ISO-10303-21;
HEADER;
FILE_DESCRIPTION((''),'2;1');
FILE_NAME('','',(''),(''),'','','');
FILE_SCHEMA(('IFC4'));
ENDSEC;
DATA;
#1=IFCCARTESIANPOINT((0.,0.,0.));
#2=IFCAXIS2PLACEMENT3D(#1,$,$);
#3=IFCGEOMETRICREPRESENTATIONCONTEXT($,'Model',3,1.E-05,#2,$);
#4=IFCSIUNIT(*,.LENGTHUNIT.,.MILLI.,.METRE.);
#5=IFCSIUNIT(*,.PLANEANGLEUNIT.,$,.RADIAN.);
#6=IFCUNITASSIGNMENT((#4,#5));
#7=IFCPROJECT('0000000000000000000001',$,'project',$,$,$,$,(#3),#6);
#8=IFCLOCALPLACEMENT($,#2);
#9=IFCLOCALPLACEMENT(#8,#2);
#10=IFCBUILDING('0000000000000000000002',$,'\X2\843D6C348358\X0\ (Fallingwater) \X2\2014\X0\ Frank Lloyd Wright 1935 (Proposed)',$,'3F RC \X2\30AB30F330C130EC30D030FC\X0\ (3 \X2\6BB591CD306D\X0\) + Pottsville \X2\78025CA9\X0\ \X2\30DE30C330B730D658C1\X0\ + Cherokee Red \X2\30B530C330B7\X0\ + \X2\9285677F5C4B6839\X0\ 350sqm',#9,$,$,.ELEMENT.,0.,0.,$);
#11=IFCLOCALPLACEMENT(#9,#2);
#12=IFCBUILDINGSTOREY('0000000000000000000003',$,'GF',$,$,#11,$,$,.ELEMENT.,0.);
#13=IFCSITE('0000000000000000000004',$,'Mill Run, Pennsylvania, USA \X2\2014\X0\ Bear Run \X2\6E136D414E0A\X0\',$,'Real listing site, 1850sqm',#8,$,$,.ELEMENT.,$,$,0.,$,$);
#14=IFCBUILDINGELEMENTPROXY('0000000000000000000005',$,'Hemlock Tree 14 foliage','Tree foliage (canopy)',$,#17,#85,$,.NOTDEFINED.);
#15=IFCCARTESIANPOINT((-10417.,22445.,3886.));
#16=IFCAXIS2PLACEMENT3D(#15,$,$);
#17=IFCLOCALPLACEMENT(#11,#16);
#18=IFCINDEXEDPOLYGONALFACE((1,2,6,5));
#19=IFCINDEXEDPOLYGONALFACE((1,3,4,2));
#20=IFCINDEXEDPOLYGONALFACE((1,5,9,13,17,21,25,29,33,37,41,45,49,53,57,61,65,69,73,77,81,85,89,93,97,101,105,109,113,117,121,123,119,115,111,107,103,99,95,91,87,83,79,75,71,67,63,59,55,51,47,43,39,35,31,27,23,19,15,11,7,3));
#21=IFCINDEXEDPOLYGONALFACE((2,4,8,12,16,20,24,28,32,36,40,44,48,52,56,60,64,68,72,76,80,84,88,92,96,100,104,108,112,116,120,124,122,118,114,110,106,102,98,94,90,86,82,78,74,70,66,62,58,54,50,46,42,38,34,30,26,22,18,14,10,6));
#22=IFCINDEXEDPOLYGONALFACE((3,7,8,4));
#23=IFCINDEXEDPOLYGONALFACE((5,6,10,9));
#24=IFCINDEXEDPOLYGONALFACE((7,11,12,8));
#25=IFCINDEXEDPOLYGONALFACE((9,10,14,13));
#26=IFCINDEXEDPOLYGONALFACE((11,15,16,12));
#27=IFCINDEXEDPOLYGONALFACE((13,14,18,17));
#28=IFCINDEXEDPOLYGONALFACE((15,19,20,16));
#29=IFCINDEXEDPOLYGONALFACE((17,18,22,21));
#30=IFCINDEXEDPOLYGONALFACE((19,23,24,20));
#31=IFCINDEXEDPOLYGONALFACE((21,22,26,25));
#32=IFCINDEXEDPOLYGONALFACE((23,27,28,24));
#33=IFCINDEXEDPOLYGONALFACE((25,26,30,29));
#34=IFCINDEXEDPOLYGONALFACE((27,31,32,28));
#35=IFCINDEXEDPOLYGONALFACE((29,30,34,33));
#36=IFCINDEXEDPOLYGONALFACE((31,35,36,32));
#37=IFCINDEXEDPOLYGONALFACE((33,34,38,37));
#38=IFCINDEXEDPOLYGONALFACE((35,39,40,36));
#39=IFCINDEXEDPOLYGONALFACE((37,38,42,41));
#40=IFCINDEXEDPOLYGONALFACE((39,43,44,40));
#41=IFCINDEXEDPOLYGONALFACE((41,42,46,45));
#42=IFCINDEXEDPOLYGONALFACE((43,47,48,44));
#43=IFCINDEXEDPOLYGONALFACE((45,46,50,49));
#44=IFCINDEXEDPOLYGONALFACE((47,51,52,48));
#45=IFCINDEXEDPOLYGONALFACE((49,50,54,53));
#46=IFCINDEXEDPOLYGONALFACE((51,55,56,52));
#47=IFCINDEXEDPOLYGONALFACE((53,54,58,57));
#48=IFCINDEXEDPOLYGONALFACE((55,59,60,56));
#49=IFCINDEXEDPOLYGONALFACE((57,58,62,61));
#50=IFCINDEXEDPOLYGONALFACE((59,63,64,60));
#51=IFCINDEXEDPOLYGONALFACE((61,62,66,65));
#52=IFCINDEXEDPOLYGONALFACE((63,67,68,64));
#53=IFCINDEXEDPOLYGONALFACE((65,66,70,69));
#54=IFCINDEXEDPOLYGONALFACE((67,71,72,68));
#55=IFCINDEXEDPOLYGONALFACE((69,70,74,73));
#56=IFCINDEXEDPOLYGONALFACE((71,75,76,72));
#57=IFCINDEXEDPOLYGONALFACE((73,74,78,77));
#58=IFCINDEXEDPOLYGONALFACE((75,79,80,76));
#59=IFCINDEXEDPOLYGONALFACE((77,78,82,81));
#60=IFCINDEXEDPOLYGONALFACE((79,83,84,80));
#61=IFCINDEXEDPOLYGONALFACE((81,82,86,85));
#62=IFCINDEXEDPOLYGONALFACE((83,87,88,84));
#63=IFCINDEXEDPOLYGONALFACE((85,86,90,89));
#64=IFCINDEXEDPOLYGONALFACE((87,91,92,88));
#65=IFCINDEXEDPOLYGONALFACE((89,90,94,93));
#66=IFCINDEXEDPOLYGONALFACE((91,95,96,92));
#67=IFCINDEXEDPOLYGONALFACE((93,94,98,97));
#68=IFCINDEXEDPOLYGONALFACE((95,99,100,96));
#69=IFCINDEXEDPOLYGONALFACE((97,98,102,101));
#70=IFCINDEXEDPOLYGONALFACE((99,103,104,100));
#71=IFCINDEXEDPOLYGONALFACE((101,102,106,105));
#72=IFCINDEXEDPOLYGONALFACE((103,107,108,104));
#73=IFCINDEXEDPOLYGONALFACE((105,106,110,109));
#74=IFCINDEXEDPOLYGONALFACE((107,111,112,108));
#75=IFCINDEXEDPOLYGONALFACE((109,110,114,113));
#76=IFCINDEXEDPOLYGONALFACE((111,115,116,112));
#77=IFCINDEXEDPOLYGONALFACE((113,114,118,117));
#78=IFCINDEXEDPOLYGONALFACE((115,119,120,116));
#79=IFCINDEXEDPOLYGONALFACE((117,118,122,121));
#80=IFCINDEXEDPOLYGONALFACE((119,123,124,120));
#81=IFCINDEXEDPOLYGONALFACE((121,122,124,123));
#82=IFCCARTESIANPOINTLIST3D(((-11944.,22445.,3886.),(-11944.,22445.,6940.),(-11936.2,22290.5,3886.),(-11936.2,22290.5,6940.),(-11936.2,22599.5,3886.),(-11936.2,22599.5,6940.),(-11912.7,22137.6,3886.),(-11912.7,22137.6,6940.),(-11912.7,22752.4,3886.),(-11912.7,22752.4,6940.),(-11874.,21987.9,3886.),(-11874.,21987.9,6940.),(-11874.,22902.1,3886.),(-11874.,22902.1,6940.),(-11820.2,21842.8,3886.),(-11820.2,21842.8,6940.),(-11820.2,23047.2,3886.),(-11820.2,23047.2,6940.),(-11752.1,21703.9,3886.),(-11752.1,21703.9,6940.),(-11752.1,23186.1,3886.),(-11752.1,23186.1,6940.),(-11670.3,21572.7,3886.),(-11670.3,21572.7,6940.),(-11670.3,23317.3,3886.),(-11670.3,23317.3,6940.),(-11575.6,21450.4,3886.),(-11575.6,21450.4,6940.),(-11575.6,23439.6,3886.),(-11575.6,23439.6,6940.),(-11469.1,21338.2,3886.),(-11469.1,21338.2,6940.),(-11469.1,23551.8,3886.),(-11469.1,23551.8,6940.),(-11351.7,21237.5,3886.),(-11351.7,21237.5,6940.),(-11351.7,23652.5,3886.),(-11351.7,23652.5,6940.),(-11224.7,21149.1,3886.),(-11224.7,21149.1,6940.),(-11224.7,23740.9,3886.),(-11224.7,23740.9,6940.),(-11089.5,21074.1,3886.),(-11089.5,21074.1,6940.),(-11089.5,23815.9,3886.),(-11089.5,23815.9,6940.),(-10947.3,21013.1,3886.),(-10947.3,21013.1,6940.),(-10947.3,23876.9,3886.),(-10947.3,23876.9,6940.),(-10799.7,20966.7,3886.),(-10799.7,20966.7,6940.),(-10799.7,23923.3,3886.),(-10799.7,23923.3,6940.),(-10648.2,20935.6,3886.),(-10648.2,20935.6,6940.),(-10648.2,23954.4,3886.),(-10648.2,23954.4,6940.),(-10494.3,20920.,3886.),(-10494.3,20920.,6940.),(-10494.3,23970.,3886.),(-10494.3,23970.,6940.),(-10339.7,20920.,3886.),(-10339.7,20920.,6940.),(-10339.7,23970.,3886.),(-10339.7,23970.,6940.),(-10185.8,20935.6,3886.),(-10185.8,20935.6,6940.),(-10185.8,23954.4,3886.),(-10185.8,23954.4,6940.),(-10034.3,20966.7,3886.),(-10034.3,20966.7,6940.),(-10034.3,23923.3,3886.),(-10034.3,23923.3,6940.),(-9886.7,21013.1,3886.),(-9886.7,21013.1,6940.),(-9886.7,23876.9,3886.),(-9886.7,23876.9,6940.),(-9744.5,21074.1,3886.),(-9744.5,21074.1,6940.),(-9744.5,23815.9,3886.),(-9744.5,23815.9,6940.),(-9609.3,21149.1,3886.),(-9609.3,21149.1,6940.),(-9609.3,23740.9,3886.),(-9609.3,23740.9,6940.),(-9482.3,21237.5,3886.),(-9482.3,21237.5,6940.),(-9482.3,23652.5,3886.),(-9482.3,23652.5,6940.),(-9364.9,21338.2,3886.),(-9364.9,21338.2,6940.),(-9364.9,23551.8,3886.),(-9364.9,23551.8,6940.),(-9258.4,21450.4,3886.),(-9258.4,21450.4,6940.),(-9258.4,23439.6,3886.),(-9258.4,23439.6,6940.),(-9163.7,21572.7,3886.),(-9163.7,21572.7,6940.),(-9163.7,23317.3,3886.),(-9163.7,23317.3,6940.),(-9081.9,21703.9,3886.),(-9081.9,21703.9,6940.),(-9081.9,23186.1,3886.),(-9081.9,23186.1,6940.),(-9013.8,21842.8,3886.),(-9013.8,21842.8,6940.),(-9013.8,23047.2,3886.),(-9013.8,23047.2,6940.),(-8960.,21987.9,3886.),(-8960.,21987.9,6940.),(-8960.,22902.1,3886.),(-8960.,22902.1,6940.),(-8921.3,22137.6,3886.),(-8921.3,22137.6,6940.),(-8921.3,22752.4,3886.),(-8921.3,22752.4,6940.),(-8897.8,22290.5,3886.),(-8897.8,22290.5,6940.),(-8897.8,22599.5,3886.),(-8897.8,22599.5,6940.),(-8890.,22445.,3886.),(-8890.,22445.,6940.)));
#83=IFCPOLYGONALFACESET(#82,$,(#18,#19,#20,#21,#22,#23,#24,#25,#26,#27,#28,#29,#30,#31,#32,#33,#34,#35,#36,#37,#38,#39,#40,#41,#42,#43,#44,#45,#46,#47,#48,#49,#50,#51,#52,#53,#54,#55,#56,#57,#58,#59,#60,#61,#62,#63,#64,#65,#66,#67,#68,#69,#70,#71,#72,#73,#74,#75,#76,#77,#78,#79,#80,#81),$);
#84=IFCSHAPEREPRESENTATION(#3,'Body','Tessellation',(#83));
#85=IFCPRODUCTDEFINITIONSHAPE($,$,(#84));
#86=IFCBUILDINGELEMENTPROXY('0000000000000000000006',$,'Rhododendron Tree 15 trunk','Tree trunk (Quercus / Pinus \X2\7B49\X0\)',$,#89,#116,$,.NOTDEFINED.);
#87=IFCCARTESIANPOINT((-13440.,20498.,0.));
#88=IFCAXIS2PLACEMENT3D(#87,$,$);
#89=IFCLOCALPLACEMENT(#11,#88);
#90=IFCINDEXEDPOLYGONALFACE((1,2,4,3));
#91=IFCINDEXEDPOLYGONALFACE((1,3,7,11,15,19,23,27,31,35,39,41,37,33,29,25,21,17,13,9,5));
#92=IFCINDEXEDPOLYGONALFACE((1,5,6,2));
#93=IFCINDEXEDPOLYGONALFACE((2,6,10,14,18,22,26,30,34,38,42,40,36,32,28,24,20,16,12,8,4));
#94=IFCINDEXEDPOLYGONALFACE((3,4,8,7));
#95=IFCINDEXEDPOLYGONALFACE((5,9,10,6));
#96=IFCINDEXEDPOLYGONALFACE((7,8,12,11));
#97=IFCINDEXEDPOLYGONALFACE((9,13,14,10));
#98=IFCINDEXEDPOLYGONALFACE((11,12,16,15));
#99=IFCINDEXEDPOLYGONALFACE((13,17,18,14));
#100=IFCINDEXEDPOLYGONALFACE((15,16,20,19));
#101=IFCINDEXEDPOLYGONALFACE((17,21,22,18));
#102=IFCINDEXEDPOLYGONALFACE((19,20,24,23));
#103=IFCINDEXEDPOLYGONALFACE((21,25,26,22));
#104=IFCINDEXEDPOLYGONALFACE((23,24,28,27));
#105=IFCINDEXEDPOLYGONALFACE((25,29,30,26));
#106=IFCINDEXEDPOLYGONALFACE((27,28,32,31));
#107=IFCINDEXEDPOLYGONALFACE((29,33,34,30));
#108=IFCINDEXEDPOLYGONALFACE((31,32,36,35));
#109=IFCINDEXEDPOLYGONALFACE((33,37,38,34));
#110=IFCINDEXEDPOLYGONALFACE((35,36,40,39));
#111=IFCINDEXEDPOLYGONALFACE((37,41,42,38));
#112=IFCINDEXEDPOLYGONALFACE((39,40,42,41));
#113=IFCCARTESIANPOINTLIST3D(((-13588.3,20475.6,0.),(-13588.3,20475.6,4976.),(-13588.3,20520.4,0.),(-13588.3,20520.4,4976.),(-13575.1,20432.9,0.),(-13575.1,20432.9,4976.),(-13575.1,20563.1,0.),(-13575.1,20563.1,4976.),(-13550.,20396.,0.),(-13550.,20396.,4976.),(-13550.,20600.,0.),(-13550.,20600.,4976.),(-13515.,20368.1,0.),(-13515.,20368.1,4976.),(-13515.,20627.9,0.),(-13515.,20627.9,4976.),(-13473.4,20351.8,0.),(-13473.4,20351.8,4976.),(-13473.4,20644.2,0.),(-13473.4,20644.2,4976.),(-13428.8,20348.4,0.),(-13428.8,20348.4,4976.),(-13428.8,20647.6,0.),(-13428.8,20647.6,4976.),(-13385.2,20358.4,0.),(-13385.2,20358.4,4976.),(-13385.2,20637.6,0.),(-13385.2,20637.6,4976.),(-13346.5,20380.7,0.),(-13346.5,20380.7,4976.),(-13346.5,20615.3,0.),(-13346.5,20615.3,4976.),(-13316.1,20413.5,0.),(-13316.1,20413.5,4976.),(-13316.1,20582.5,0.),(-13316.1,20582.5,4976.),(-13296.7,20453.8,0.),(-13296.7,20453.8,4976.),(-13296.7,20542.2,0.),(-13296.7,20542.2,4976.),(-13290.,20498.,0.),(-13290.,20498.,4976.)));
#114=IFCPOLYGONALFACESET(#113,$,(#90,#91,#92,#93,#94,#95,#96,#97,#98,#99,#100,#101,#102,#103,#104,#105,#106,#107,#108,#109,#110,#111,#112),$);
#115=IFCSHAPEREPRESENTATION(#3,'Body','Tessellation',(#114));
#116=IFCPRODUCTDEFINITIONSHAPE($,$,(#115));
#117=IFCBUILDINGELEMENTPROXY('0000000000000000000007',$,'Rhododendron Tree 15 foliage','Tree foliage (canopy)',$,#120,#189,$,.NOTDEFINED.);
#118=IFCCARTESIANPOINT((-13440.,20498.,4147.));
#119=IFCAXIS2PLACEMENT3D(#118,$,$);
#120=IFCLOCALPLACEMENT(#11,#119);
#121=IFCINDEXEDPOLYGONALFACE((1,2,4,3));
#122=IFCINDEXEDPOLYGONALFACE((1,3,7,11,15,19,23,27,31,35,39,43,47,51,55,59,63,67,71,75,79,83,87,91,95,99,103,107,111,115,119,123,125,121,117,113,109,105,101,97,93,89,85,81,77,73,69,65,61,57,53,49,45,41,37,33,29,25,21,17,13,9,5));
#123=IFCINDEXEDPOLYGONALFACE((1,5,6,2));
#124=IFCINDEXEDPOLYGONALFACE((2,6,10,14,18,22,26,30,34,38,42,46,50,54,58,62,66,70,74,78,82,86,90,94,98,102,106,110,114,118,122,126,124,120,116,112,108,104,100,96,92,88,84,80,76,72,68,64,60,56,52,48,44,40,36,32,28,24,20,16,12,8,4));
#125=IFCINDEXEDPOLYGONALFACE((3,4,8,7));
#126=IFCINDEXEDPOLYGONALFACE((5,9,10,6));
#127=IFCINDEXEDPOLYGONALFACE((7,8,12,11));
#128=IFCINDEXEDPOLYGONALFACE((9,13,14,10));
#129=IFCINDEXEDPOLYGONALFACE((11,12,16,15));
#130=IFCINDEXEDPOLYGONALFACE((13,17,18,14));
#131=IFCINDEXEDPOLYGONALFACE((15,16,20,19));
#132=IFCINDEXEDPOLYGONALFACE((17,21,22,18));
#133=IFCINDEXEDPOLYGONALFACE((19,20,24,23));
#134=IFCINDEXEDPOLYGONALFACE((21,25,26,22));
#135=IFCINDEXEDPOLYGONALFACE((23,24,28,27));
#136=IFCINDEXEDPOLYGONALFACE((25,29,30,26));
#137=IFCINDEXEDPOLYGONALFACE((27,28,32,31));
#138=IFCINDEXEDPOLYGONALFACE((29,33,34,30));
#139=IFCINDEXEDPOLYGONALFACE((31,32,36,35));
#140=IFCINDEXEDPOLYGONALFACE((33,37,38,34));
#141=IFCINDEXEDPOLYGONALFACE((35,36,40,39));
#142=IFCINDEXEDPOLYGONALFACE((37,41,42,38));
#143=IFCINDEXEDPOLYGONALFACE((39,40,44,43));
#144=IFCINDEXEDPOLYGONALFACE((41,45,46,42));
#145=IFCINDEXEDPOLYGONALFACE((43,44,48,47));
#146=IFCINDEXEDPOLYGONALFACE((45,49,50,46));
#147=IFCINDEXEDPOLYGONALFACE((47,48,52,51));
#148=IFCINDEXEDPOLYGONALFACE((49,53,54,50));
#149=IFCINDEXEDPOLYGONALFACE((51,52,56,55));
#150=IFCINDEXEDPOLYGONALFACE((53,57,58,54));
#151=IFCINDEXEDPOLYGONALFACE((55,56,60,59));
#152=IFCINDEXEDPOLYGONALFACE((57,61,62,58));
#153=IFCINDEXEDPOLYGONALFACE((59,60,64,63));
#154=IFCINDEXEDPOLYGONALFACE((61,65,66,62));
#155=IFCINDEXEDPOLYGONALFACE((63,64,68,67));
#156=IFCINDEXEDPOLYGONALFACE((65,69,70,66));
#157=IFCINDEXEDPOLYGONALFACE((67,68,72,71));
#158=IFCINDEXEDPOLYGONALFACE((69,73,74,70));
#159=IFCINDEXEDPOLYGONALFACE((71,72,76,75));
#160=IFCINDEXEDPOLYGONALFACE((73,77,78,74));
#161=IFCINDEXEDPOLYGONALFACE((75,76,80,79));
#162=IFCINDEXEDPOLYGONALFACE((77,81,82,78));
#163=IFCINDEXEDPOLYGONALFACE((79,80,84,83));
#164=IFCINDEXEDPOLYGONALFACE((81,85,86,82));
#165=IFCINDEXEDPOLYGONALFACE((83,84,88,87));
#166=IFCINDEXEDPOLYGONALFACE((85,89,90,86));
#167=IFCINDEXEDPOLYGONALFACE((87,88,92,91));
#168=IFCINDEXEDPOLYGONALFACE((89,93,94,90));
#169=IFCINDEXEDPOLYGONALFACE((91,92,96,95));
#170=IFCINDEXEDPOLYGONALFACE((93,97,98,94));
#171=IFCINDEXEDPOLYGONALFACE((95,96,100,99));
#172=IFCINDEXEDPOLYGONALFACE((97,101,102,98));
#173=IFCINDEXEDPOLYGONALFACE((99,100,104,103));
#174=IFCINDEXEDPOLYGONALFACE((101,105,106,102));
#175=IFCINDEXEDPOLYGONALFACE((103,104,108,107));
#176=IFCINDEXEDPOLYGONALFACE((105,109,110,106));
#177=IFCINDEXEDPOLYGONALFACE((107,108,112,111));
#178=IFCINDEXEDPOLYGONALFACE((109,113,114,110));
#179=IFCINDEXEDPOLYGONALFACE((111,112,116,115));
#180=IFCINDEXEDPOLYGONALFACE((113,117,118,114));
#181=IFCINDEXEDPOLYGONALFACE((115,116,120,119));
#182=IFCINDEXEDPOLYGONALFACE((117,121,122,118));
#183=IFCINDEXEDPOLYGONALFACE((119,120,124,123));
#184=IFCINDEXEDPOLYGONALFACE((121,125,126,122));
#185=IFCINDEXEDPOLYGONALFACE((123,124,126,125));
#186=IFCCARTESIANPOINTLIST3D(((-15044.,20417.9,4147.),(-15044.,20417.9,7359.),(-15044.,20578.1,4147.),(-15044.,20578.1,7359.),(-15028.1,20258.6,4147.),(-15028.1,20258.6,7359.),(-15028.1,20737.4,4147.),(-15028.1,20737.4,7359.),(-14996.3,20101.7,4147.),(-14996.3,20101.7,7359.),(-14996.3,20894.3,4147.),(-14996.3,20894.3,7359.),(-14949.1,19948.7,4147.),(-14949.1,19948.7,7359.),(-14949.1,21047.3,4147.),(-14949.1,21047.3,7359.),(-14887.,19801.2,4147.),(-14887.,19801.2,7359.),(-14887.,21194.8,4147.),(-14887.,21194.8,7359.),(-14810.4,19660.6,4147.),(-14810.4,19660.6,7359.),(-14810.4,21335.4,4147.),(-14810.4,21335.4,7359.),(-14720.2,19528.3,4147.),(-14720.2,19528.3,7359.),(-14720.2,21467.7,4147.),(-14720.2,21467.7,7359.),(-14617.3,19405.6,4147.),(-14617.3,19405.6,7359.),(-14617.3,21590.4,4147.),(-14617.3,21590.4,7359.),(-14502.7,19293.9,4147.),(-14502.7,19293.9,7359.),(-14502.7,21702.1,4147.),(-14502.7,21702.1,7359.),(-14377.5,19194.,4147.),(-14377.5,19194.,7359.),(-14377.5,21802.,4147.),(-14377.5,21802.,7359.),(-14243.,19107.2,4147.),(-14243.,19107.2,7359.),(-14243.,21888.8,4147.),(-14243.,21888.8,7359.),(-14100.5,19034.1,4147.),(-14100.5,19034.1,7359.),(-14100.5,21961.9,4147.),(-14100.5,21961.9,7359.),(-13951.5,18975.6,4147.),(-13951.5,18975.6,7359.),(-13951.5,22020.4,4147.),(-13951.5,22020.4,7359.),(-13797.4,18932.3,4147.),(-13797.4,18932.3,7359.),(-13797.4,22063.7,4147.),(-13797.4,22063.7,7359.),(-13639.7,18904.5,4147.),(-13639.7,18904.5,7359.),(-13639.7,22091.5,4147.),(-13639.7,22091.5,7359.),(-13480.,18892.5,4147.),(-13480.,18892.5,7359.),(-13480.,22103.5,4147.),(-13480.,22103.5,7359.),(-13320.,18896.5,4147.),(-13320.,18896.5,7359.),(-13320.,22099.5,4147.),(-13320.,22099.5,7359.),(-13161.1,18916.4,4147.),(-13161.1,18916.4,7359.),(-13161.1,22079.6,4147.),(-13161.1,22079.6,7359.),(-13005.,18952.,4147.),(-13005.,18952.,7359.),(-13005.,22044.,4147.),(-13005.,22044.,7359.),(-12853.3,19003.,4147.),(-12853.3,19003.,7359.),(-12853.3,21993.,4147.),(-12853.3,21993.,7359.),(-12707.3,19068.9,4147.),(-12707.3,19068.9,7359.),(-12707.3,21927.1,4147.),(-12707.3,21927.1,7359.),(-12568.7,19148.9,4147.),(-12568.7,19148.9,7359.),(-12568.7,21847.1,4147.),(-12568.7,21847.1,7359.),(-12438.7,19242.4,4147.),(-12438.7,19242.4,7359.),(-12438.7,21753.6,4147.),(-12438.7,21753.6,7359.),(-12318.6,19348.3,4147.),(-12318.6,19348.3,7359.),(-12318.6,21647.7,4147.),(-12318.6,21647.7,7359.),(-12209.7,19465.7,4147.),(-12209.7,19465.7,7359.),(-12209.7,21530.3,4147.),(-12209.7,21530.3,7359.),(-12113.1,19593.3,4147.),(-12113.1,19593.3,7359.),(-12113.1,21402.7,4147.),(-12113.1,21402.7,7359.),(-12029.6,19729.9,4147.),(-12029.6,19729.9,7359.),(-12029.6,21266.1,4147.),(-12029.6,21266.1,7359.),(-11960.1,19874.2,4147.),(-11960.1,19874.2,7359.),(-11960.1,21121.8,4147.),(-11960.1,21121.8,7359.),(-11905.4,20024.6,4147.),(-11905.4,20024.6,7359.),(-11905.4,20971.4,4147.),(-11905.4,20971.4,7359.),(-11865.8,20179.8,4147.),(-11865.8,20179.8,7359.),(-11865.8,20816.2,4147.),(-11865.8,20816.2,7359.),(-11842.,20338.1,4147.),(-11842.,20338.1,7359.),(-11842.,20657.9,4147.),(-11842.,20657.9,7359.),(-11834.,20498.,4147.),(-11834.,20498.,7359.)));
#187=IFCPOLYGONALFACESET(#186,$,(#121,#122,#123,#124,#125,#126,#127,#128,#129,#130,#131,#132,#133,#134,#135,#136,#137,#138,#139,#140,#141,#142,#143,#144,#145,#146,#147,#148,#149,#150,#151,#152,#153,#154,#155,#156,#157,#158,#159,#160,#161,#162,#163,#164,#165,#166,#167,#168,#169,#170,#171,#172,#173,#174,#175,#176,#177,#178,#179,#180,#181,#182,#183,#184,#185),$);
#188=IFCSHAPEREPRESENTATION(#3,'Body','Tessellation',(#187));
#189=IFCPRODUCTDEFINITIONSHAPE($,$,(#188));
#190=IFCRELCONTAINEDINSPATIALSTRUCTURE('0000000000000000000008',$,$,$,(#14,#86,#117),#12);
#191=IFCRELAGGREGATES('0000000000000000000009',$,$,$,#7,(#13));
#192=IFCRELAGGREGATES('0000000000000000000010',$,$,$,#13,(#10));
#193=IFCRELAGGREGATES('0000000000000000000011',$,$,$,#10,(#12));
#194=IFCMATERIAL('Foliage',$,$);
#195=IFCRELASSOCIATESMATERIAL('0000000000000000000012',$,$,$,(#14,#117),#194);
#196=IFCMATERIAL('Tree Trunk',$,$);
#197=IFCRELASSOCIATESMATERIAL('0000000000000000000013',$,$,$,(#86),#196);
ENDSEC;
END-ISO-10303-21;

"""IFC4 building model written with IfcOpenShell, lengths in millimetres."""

from ifc_helpers import new_model, si_unit, frame, origin, origin_2d, place, context, project, spatial, circle, extrude, material, element, save


model = new_model("IFC4")

# Units and contexts
model_context = context("Model", 3, precision=1e-05, world=origin())
ifc_project = project(units=[si_unit("LENGTHUNIT", "METRE", prefix="MILLI"), si_unit("PLANEANGLEUNIT", "RADIAN")], contexts=[model_context])

# Site, building, storey
site_placement = place(None, origin())
site = spatial("IfcSite", under=ifc_project, at=site_placement, Name="Mill Run, Pennsylvania, USA — Bear Run 渓流上", ObjectType="Real listing site, 1850sqm", CompositionType="ELEMENT", RefElevation=0.0)
building_placement = place(site_placement, origin())
building = spatial("IfcBuilding", under=site, at=building_placement, Name="落水荘 (Fallingwater) — Frank Lloyd Wright 1935 (Proposed)", ObjectType="3F RC カンチレバー (3 段重ね) + Pottsville 砂岩 マッシブ壁 + Cherokee Red サッシ + 銅板屋根 350sqm", CompositionType="ELEMENT", ElevationOfRefHeight=0.0, ElevationOfTerrain=0.0)
storey_placement = place(building_placement, origin())
storey = spatial("IfcBuildingStorey", under=building, at=storey_placement, Name="GF", CompositionType="ELEMENT", Elevation=0.0)

# Building element proxies
ifc_material_1 = material(Name="Tree Trunk")
ifc_material_2 = material(Name="Foliage")
proxy_1_placement = place(storey_placement, frame((-10417.0, 22445.0, 3886.0)))
element("IfcBuildingElementProxy", 1, at=proxy_1_placement, inside=storey, material=ifc_material_2, Name="Hemlock Tree 14 foliage", Description="Tree foliage (canopy)", PredefinedType="NOTDEFINED", context=model_context, shape_type="SweptSolid", body=[
    extrude(circle(Radius=1527.0, at=origin_2d()), frame((-10417.0, 22445.0, 3886.0)), (0.0, 0.0, 1.0), 3054.0),
])
proxy_2_placement = place(storey_placement, frame((-13440.0, 20498.0, 0.0)))
element("IfcBuildingElementProxy", 2, at=proxy_2_placement, inside=storey, material=ifc_material_1, Name="Rhododendron Tree 15 trunk", Description="Tree trunk (Quercus / Pinus 等)", PredefinedType="NOTDEFINED", context=model_context, shape_type="SweptSolid", body=[
    extrude(circle(Radius=150.0, at=origin_2d()), frame((-13440.0, 20498.0, 0.0)), (0.0, 0.0, 1.0), 4976.0),
])
proxy_3_placement = place(storey_placement, frame((-13440.0, 20498.0, 4147.0)))
element("IfcBuildingElementProxy", 3, at=proxy_3_placement, inside=storey, material=ifc_material_2, Name="Rhododendron Tree 15 foliage", Description="Tree foliage (canopy)", PredefinedType="NOTDEFINED", context=model_context, shape_type="SweptSolid", body=[
    extrude(circle(Radius=1606.0, at=origin_2d()), frame((-13440.0, 20498.0, 4147.0)), (0.0, 0.0, 1.0), 3212.0),
])

save(model, "model.ifc")
